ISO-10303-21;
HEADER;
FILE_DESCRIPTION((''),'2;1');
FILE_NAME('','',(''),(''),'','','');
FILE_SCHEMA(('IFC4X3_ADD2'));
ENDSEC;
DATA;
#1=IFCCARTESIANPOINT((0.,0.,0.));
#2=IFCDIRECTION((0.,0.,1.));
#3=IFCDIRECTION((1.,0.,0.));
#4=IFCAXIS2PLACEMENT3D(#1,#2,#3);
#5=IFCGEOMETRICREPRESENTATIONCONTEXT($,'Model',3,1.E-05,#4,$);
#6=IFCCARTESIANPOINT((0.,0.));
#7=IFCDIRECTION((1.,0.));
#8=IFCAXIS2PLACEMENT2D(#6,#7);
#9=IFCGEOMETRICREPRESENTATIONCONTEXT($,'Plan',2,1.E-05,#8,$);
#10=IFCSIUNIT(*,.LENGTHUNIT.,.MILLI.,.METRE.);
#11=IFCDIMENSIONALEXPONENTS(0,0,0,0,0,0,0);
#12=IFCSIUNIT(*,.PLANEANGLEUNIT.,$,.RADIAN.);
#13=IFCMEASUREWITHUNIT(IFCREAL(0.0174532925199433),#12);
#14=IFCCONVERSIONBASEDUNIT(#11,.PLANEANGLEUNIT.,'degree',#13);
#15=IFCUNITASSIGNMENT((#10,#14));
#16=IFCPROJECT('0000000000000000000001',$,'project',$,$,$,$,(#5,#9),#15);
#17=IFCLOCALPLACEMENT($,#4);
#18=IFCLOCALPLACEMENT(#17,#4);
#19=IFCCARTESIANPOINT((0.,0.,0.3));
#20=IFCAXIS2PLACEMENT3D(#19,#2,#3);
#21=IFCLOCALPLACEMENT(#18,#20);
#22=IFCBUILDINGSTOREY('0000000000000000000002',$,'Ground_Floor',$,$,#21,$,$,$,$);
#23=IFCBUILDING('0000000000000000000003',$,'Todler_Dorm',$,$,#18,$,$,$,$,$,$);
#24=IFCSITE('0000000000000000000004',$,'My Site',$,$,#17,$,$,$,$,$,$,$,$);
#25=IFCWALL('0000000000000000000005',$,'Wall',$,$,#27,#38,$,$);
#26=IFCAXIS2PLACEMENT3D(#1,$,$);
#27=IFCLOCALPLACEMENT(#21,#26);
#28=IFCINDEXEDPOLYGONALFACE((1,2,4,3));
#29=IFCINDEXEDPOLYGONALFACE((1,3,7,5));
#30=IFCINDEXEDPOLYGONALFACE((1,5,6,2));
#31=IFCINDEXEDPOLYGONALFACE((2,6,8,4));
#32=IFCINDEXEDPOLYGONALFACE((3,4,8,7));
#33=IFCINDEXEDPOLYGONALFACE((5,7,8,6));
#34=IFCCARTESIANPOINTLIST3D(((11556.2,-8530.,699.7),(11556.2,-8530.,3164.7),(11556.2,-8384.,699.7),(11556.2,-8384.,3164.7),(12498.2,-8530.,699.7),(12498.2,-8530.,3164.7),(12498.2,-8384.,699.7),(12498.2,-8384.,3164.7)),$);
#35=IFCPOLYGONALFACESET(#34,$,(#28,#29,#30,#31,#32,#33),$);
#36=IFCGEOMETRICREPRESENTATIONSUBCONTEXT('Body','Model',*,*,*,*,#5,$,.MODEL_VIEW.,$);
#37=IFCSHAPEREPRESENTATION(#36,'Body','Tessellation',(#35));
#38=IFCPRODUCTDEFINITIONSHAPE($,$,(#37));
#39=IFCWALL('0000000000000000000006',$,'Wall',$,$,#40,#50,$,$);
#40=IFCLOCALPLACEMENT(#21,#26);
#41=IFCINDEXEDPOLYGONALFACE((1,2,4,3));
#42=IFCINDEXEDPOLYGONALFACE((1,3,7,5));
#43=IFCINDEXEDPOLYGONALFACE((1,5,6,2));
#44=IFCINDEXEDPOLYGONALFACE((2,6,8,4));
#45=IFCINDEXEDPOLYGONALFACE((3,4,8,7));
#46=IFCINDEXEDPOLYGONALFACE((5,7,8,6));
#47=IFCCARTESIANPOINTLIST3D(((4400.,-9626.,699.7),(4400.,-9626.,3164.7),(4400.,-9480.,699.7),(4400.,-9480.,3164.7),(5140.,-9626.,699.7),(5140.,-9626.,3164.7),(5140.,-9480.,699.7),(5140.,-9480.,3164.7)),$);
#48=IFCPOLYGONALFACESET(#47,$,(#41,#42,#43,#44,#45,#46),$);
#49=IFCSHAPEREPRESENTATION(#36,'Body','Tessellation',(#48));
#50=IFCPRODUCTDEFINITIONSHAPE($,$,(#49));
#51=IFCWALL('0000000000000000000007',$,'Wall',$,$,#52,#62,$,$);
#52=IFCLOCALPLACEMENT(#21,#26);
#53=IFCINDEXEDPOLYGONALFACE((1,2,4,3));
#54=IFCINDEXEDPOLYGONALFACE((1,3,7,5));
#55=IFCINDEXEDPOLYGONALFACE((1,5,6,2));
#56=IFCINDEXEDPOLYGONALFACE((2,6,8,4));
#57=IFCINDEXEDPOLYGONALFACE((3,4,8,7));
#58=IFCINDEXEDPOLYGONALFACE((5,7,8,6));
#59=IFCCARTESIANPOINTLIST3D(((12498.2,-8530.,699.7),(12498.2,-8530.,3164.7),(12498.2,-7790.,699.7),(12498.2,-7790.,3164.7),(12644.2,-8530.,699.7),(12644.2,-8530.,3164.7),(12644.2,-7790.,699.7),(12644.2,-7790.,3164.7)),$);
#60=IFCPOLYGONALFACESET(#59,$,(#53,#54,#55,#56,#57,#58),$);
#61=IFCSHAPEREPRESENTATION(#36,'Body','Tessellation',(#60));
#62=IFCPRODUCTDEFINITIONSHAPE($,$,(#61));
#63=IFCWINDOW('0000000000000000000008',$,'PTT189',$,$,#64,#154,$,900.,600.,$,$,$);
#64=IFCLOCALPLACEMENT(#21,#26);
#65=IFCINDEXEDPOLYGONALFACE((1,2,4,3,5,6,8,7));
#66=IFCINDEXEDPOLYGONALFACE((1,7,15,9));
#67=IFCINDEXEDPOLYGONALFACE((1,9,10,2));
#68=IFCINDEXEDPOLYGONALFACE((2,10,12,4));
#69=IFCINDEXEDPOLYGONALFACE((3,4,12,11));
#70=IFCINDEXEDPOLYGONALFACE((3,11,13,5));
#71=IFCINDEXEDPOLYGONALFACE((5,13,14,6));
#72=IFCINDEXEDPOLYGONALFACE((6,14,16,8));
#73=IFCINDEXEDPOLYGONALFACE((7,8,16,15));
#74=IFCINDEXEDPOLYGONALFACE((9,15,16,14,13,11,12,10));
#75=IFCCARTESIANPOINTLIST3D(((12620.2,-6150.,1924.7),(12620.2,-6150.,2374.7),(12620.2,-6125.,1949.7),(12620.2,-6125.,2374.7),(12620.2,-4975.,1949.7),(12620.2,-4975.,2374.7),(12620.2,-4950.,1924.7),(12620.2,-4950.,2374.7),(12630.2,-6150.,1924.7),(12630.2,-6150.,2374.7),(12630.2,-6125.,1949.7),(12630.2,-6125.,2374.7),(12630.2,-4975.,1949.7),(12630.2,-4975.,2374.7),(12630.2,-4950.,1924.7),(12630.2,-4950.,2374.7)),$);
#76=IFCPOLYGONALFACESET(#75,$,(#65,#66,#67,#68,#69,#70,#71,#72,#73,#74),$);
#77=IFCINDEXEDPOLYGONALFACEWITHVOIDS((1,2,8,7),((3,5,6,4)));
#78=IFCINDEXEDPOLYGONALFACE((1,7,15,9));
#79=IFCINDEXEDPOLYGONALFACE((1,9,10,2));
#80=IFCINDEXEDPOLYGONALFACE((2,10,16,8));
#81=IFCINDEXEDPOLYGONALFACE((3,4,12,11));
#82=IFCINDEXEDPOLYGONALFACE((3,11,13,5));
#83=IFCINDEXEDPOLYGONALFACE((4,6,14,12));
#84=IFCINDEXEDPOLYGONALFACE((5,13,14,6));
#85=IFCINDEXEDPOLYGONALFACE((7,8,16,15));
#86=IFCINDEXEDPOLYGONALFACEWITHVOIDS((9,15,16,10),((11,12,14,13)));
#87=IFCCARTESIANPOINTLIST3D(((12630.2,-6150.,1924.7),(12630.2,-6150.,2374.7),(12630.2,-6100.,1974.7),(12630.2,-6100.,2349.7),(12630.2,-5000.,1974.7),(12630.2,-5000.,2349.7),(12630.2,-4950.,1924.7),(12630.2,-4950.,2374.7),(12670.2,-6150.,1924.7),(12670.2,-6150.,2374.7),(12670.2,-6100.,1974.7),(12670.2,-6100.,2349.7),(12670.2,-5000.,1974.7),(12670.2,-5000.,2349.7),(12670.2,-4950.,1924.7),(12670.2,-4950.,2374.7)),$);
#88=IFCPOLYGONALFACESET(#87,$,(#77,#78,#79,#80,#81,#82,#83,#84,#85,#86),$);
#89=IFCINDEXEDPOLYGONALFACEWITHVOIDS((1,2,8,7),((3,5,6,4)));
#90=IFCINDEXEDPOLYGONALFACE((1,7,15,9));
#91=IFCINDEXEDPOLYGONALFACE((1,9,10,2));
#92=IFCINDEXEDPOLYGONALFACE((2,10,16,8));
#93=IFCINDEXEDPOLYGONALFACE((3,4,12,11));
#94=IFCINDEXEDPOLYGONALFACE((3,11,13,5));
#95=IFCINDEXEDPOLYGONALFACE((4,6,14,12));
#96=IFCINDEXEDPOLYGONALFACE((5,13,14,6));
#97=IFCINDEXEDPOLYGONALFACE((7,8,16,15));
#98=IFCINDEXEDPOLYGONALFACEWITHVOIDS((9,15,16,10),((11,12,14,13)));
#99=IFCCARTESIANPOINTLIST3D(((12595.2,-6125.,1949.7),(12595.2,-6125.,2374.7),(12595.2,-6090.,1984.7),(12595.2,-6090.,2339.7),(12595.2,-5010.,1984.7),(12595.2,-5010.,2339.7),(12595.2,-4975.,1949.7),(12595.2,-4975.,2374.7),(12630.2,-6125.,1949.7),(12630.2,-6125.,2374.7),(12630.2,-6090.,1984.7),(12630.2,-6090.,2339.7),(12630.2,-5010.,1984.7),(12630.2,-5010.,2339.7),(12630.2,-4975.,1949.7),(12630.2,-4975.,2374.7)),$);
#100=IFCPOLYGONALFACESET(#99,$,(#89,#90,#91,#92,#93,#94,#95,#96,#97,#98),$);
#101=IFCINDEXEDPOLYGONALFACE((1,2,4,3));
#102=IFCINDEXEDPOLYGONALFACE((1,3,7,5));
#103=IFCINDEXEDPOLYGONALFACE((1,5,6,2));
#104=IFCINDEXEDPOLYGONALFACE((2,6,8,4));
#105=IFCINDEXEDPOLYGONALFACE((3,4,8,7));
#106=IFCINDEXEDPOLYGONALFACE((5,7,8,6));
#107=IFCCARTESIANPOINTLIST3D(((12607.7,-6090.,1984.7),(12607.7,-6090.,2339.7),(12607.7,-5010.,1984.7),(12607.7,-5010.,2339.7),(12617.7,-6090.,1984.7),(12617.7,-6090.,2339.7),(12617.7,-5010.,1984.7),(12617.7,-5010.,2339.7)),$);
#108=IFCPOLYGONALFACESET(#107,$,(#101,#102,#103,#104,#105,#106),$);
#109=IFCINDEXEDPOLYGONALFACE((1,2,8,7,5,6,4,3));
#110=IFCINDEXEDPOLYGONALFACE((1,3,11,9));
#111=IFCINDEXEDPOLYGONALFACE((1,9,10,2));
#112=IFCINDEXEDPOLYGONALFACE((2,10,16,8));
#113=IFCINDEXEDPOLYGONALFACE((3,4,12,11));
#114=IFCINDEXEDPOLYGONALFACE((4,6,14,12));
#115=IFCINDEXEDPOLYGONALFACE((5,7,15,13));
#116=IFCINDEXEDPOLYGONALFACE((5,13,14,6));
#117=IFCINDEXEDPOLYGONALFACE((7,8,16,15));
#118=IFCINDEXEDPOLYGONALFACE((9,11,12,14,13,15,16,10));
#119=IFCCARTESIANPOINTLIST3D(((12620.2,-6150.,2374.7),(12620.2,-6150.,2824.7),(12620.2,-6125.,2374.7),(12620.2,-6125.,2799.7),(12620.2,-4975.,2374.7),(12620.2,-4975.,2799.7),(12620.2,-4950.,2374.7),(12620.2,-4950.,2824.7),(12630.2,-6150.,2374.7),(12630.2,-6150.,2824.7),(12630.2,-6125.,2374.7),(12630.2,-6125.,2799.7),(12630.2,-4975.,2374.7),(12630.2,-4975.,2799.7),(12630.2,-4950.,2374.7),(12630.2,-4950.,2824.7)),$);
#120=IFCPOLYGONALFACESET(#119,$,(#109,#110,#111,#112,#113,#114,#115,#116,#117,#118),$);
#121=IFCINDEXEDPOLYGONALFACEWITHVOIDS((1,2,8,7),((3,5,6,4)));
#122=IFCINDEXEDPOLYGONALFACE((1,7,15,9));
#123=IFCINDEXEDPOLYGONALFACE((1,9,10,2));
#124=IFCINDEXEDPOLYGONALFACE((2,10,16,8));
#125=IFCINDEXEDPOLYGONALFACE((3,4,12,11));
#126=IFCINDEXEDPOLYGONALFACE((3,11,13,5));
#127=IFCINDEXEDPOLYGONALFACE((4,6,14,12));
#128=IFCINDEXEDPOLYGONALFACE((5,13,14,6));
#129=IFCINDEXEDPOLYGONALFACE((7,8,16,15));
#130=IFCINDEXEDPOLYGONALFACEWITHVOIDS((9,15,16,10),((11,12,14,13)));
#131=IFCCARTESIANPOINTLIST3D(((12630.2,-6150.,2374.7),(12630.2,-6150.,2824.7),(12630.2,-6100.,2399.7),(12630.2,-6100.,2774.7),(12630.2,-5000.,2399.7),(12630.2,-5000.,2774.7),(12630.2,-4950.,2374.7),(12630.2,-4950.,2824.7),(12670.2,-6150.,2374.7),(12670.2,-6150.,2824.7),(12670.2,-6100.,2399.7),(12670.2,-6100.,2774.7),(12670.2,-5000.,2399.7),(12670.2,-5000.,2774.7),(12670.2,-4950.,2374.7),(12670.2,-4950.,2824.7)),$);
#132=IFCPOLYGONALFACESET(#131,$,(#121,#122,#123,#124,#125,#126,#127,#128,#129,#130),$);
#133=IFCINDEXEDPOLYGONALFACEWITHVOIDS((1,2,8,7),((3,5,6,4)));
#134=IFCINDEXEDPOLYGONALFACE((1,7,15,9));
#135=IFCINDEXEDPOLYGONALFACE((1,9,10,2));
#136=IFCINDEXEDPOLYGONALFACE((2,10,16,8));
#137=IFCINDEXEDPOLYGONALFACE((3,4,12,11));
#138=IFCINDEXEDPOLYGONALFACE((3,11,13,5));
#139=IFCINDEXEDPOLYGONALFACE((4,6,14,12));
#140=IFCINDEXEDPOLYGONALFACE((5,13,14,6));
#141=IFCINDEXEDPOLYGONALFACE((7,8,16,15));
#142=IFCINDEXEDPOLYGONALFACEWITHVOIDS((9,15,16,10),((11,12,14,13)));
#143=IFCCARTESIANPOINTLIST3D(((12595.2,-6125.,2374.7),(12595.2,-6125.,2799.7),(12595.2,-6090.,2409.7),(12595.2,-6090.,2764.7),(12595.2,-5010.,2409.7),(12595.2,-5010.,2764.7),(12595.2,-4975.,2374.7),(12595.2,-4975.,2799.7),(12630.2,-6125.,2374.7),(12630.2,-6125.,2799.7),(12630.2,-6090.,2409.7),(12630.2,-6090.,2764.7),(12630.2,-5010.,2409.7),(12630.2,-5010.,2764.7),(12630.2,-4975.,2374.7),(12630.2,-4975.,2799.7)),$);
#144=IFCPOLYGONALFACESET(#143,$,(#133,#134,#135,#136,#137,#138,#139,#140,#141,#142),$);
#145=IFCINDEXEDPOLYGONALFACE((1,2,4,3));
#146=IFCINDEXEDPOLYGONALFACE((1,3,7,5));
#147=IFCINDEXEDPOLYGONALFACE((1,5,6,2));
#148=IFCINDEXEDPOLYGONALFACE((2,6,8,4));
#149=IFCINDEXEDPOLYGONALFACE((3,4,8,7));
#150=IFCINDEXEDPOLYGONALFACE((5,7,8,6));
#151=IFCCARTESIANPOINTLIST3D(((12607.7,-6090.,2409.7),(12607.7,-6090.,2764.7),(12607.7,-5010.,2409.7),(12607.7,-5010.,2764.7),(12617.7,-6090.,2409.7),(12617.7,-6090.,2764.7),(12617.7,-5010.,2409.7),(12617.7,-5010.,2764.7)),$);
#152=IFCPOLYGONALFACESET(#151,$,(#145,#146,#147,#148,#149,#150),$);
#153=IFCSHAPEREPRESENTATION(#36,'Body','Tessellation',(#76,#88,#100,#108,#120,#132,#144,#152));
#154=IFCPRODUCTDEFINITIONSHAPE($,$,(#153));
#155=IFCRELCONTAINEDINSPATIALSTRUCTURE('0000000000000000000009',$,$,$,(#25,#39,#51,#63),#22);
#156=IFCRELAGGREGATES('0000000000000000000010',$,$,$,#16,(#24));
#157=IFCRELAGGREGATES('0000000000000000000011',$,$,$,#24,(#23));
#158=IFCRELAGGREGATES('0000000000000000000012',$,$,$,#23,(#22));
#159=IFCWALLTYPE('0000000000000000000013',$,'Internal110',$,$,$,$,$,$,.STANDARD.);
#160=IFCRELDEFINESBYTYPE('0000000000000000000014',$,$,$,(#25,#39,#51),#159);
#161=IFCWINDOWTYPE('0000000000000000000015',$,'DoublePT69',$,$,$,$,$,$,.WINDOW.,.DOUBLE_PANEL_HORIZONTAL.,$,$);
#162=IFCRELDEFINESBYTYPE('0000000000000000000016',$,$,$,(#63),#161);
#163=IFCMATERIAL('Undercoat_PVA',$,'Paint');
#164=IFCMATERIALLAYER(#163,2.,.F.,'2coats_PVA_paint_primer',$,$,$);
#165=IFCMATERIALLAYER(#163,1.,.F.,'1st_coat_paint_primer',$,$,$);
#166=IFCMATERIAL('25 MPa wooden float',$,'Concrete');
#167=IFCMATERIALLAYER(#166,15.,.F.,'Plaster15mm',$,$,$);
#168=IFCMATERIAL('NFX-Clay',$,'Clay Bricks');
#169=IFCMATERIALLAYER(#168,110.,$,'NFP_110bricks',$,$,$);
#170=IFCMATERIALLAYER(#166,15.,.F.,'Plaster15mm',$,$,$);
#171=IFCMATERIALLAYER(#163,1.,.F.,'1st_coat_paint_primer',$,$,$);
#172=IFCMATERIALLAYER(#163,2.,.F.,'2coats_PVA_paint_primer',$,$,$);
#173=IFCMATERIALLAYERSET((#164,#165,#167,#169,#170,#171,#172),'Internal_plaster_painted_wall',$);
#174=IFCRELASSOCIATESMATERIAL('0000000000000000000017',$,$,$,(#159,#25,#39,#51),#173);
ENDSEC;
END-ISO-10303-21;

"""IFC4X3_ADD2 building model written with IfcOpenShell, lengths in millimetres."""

from ifc_helpers import new_model, entity, si_unit, converted_unit, frame, origin_with_axes, origin_2d_with_axis, place, context, subcontext, project, spatial, line, indexed_curve, outline, extrude, shape, source, transform, mapped, material, layer, layer_set, layer_usage, type_object, type_shapes, element, save


model = new_model("IFC4X3_ADD2")

# Units and contexts
model_context = context("Model", 3, precision=1e-05, world=origin_with_axes())
plan_context = context("Plan", 2, precision=1e-05, world=origin_2d_with_axis())
body_context_1 = subcontext(model_context, "Body", "Model", "MODEL_VIEW")
body_context_2 = subcontext(plan_context, "Body", "Plan", "PLAN_VIEW")
ifc_project = project(units=[si_unit("LENGTHUNIT", "METRE", prefix="MILLI"), converted_unit("PLANEANGLEUNIT", "degree", entity("IfcReal", 0.0174532925199433), si_unit("PLANEANGLEUNIT", "RADIAN"), dimensions=[0, 0, 0, 0, 0, 0, 0])], contexts=[model_context, plan_context])

# Site, building, storey
site_placement = place(None, origin_with_axes())
site = spatial("IfcSite", under=ifc_project, at=site_placement, Name="My Site")
building_placement = place(site_placement, origin_with_axes())
building = spatial("IfcBuilding", under=site, at=building_placement, Name="Todler_Dorm")
storey_placement = place(building_placement, frame((0.0, 0.0, 0.3), z_axis=(0.0, 0.0, 1.0), x_axis=(1.0, 0.0, 0.0)))
storey = spatial("IfcBuildingStorey", under=building, at=storey_placement, Name="Ground_Floor")

# Shared definitions
window_type_1 = type_object("IfcWindowType", Name="DoublePT69", PartitioningType="DOUBLE_PANEL_HORIZONTAL", PredefinedType="WINDOW")
shared_shape_1 = source(origin_with_axes(), body_context_1, "Body", "SweptSolid", [
    extrude(outline(indexed_curve([(1200.0, 450.0), (1200.0, 0.0), (0.0, 0.0), (0.0, 450.0), (25.0, 450.0), (25.0, 25.0), (1175.0, 25.0), (1175.0, 450.0)], segments=[line(1, 2, 3, 4, 5, 6, 7, 8, 1)])), frame((0.0, 90.0, 0.0), z_axis=(0.0, -1.0, 0.0), x_axis=(1.0, 0.0, 0.0)), (0.0, 0.0, -1.0), 10.0),
    extrude(outline(indexed_curve([(0.0, 0.0), (1200.0, 0.0), (1200.0, 450.0), (0.0, 450.0)], segments=[line(1, 2, 3, 4, 1)]), holes=[indexed_curve([(50.0, 50.0), (1150.0, 50.0), (1150.0, 425.0), (50.0, 425.0)], segments=[line(1, 2, 3, 4, 1)])]), frame((0.0, 50.0, 0.0), z_axis=(0.0, -1.0, 0.0), x_axis=(1.0, 0.0, 0.0)), (0.0, 0.0, -1.0), 40.0),
    extrude(outline(indexed_curve([(0.0, 0.0), (1150.0, 0.0), (1150.0, 425.0), (0.0, 425.0)], segments=[line(1, 2, 3, 4, 1)]), holes=[indexed_curve([(35.0, 35.0), (1115.0, 35.0), (1115.0, 390.0), (35.0, 390.0)], segments=[line(1, 2, 3, 4, 1)])]), frame((25.0, 90.0, 25.0), z_axis=(0.0, -1.0, 0.0), x_axis=(1.0, 0.0, 0.0)), (0.0, 0.0, -1.0), 35.0),
    extrude(outline(indexed_curve([(35.0, 35.0), (1115.0, 35.0), (1115.0, 390.0), (35.0, 390.0)], segments=[line(1, 2, 3, 4, 1)])), frame((25.0, 102.5, 25.0), z_axis=(0.0, -1.0, 0.0), x_axis=(1.0, 0.0, 0.0)), (0.0, 0.0, -1.0), 10.0),
    extrude(outline(indexed_curve([(0.0, 0.0), (0.0, 450.0), (1200.0, 450.0), (1200.0, 0.0), (1175.0, 0.0), (1175.0, 425.0), (25.0, 425.0), (25.0, 0.0)], segments=[line(1, 2, 3, 4, 5, 6, 7, 8, 1)])), frame((0.0, 90.0, 450.0), z_axis=(0.0, -1.0, 0.0), x_axis=(1.0, 0.0, 0.0)), (0.0, 0.0, -1.0), 10.0),
    extrude(outline(indexed_curve([(0.0, 0.0), (1200.0, 0.0), (1200.0, 450.0), (0.0, 450.0)], segments=[line(1, 2, 3, 4, 1)]), holes=[indexed_curve([(50.0, 25.0), (1150.0, 25.0), (1150.0, 400.0), (50.0, 400.0)], segments=[line(1, 2, 3, 4, 1)])]), frame((0.0, 50.0, 450.0), z_axis=(0.0, -1.0, 0.0), x_axis=(1.0, 0.0, 0.0)), (0.0, 0.0, -1.0), 40.0),
    extrude(outline(indexed_curve([(0.0, 0.0), (1150.0, 0.0), (1150.0, 425.0), (0.0, 425.0)], segments=[line(1, 2, 3, 4, 1)]), holes=[indexed_curve([(35.0, 35.0), (1115.0, 35.0), (1115.0, 390.0), (35.0, 390.0)], segments=[line(1, 2, 3, 4, 1)])]), frame((25.0, 90.0, 450.0), z_axis=(0.0, -1.0, 0.0), x_axis=(1.0, 0.0, 0.0)), (0.0, 0.0, -1.0), 35.0),
    extrude(outline(indexed_curve([(35.0, 35.0), (1115.0, 35.0), (1115.0, 390.0), (35.0, 390.0)], segments=[line(1, 2, 3, 4, 1)])), frame((25.0, 102.5, 450.0), z_axis=(0.0, -1.0, 0.0), x_axis=(1.0, 0.0, 0.0)), (0.0, 0.0, -1.0), 10.0),
])
shared_shape_2 = source(origin_with_axes(), body_context_2, "Body", "Curve2D", [
    entity("IfcIndexedPolyCurve", entity("IfcCartesianPointList2D", [[50.0, 50.0], [1150.0, 50.0]])),
    entity("IfcIndexedPolyCurve", entity("IfcCartesianPointList2D", [[0.0, 100.0], [25.0, 100.0], [25.0, 90.0], [50.0, 90.0], [50.0, 50.0], [0.0, 50.0]]), [entity("IfcLineIndex", [1, 2, 3, 4, 5, 6, 1])]),
    entity("IfcIndexedPolyCurve", entity("IfcCartesianPointList2D", [[1200.0, 100.0], [1175.0, 100.0], [1175.0, 90.0], [1150.0, 90.0], [1150.0, 50.0], [1200.0, 50.0]]), [entity("IfcLineIndex", [1, 2, 3, 4, 5, 6, 1])]),
    entity("IfcIndexedPolyCurve", entity("IfcCartesianPointList2D", [[25.0, 90.0], [60.0, 90.0], [60.0, 125.0], [25.0, 125.0]]), [entity("IfcLineIndex", [1, 2, 3, 4, 1])]),
    entity("IfcIndexedPolyCurve", entity("IfcCartesianPointList2D", [[1175.0, 90.0], [1140.0, 90.0], [1140.0, 125.0], [1175.0, 125.0]]), [entity("IfcLineIndex", [1, 2, 3, 4, 1])]),
    entity("IfcIndexedPolyCurve", entity("IfcCartesianPointList2D", [[60.0, 90.0], [1140.0, 90.0]])),
    entity("IfcIndexedPolyCurve", entity("IfcCartesianPointList2D", [[60.0, 125.0], [1140.0, 125.0]])),
    entity("IfcIndexedPolyCurve", entity("IfcCartesianPointList2D", [[60.0, 107.5], [1140.0, 107.5]])),
])
type_shapes(window_type_1, [shared_shape_1, shared_shape_2])

# Shared definitions
ifc_material_1 = material(Name="Undercoat_PVA", Category="Paint")
ifc_layer_1 = layer(ifc_material_1, 2.0, ventilated=False, Name="2coats_PVA_paint_primer")
ifc_layer_2 = layer(ifc_material_1, 1.0, ventilated=False, Name="1st_coat_paint_primer")
ifc_material_2 = material(Name="25 MPa wooden float", Category="Concrete")
ifc_layer_3 = layer(ifc_material_2, 15.0, ventilated=False, Name="Plaster15mm")
ifc_material_3 = material(Name="NFX-Clay", Category="Clay Bricks")
ifc_layer_4 = layer(ifc_material_3, 110.0, Name="NFP_110bricks")
ifc_layer_5 = layer(ifc_material_2, 15.0, ventilated=False, Name="Plaster15mm")
ifc_layer_6 = layer(ifc_material_1, 1.0, ventilated=False, Name="1st_coat_paint_primer")
ifc_layer_7 = layer(ifc_material_1, 2.0, ventilated=False, Name="2coats_PVA_paint_primer")
ifc_layer_set_1 = layer_set([ifc_layer_1, ifc_layer_2, ifc_layer_3, ifc_layer_4, ifc_layer_5, ifc_layer_6, ifc_layer_7], Name="Internal_plaster_painted_wall")
wall_type_1 = type_object("IfcWallType", Name="Internal110", PredefinedType="STANDARD", material=ifc_layer_set_1)

# Wall
ifc_layer_usage_1 = layer_usage(ifc_layer_set_1, "AXIS2", "POSITIVE", 0.0)
wall_1_placement = place(storey_placement, frame((11556.2, -8530.0, 699.7), z_axis=(0.0, 0.0, 1.0), x_axis=(1.0, 0.0, 0.0)))
element("IfcWall", 1, at=wall_1_placement, inside=storey, type_object=wall_type_1, material=ifc_layer_usage_1, Name="Wall", context=body_context_1, shape_type="SweptSolid", body=[
    extrude(outline(indexed_curve([(0.0, 0.0), (0.0, 146.0), (942.0, 146.0), (942.0, 0.0)], segments=[line(1, 2, 3, 4, 1)])), origin_with_axes(), (0.0, 0.0, 1.0), 2465.0),
])

# Walls
ifc_layer_usage_2 = layer_usage(ifc_layer_set_1, "AXIS2", "POSITIVE", 0.0)
wall_2_placement = place(storey_placement, frame((5140.0, -9480.0, 699.7), z_axis=(0.0, 0.0, 1.0), x_axis=(-1.0, 0.0, 0.0)))
element("IfcWall", 2, at=wall_2_placement, inside=storey, type_object=wall_type_1, material=ifc_layer_usage_2, Name="Wall", context=body_context_1, shape_type="SweptSolid", body=[
    extrude(outline(indexed_curve([(0.0, 0.0), (0.0, 146.0), (740.0, 146.0), (740.0, 0.0)], segments=[line(1, 2, 3, 4, 1)])), origin_with_axes(), (0.0, 0.0, 1.0), 2465.0),
])
ifc_layer_usage_3 = layer_usage(ifc_layer_set_1, "AXIS2", "NEGATIVE", 0.0)
wall_3_placement = place(storey_placement, frame((12498.2, -8530.0, 699.7), z_axis=(0.0, 0.0, 1.0), x_axis=(0.0, 1.0, 0.0)))
element("IfcWall", 3, at=wall_3_placement, inside=storey, type_object=wall_type_1, material=ifc_layer_usage_3, Name="Wall", context=body_context_1, shape_type="SweptSolid", body=[
    extrude(outline(indexed_curve([(0.0, -146.0), (0.0, 0.0), (740.0, 0.0), (740.0, -146.0)], segments=[line(1, 2, 3, 4, 1)])), origin_with_axes(), (0.0, 0.0, 1.0), 2465.0),
])

# Window
window_1_placement = place(storey_placement, frame((12720.2, -6150.0, 1924.7), z_axis=(0.0, 0.0, 1.0), x_axis=(0.0, 1.0, 0.0)))
element("IfcWindow", 4, at=window_1_placement, inside=storey, type_object=window_type_1, Name="PTT189", OverallHeight=900.0, OverallWidth=600.0, shapes=[
    shape(body_context_1, "Body", "MappedRepresentation", [mapped(shared_shape_1, transform((0.0, 0.0, 0.0), x_axis=(1.0, 0.0, 0.0), y_axis=(0.0, 1.0, 0.0), z_axis=(0.0, 0.0, 1.0), scale=1.0))]),
    shape(body_context_2, "Body", "MappedRepresentation", [mapped(shared_shape_2, transform((0.0, 0.0, 0.0), x_axis=(1.0, 0.0, 0.0), y_axis=(0.0, 1.0, 0.0), z_axis=(0.0, 0.0, 1.0), scale=1.0))]),
])

save(model, "model.ifc")
